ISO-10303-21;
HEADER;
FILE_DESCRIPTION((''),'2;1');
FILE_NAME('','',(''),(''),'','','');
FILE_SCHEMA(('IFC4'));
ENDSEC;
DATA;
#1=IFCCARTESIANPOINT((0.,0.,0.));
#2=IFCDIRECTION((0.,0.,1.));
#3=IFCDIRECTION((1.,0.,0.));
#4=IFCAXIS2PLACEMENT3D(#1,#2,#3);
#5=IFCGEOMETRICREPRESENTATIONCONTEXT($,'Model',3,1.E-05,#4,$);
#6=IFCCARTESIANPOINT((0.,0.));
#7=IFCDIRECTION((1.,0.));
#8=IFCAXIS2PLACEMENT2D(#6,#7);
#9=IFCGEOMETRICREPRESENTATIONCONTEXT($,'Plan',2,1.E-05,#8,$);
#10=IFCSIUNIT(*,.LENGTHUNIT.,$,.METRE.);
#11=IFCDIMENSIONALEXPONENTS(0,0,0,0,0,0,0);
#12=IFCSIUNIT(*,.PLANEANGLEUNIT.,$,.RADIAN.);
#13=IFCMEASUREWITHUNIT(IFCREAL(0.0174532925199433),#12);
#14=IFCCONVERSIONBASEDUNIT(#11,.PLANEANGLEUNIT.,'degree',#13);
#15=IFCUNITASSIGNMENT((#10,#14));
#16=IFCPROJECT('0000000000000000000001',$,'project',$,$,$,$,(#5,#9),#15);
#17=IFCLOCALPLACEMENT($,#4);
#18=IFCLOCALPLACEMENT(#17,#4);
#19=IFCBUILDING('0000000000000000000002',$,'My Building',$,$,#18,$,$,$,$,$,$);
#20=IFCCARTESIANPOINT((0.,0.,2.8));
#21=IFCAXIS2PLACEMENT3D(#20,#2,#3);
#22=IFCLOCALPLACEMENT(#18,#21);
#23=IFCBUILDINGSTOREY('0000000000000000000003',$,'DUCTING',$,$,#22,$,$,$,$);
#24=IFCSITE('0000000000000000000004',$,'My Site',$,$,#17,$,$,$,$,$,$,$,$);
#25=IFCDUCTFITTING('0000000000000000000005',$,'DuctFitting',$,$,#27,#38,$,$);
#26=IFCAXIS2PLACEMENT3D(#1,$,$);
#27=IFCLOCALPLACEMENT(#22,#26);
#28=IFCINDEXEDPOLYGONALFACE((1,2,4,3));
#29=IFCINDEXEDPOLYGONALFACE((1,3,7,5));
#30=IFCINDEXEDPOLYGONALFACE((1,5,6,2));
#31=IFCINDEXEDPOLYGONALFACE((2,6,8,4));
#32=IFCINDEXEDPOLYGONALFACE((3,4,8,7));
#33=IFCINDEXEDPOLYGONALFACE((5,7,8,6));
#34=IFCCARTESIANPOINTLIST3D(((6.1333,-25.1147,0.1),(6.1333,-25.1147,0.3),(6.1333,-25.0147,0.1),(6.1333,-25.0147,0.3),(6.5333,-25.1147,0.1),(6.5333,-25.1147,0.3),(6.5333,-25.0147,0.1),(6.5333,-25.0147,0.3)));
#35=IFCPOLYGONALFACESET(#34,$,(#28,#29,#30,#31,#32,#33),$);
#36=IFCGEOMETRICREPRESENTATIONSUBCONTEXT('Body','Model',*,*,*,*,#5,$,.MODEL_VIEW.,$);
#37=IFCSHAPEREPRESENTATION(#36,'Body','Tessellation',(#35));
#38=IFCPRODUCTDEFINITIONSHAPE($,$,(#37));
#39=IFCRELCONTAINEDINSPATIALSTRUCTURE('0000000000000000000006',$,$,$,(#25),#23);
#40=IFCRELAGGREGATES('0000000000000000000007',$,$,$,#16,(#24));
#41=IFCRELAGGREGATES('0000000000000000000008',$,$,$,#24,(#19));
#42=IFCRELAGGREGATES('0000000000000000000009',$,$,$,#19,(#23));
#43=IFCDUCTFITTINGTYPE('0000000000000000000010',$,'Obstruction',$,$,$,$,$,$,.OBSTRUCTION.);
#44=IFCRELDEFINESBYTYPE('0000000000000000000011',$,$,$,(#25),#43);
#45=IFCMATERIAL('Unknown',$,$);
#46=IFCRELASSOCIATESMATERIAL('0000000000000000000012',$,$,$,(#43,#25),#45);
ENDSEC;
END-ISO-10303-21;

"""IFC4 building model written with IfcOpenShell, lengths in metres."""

from ifc_helpers import new_model, entity, si_unit, converted_unit, frame, origin_with_axes, origin_2d_with_axis, place, context, subcontext, project, spatial, rectangle, extrude, material, material_profile, profile_set, profile_usage, type_object, element, save


model = new_model("IFC4")

# Units and contexts
model_context = context("Model", 3, precision=1e-05, world=origin_with_axes())
plan_context = context("Plan", 2, precision=1e-05, world=origin_2d_with_axis())
body_context = subcontext(model_context, "Body", "Model", "MODEL_VIEW")
ifc_project = project(units=[si_unit("LENGTHUNIT", "METRE"), converted_unit("PLANEANGLEUNIT", "degree", entity("IfcReal", 0.0174532925199433), si_unit("PLANEANGLEUNIT", "RADIAN"), dimensions=[0, 0, 0, 0, 0, 0, 0])], contexts=[model_context, plan_context])

# Site, building, storey
site_placement = place(None, origin_with_axes())
site = spatial("IfcSite", under=ifc_project, at=site_placement, Name="My Site")
building_placement = place(site_placement, origin_with_axes())
building = spatial("IfcBuilding", under=site, at=building_placement, Name="My Building")
storey_placement = place(building_placement, frame((0.0, 0.0, 2.8), z_axis=(0.0, 0.0, 1.0), x_axis=(1.0, 0.0, 0.0)))
storey = spatial("IfcBuildingStorey", under=building, at=storey_placement, Name="DUCTING")

# Shared definitions
ifc_material = material(Name="Unknown")

# Duct fitting
ifc_material_profile_1 = material_profile(ifc_material, rectangle(XDim=0.4, YDim=0.2))
ifc_profile_set_1 = profile_set([ifc_material_profile_1])
duct_fitting_type_1 = type_object("IfcDuctFittingType", Name="Obstruction", PredefinedType="OBSTRUCTION", material=ifc_profile_set_1)
ifc_profile_usage_1 = profile_usage(ifc_profile_set_1, cardinal=5)
duct_fitting_1_placement = place(storey_placement, frame((6.3333, -25.0147, 0.2), z_axis=(0.0, -1.0, 0.0), x_axis=(1.0, 0.0, 0.0)))
element("IfcDuctFitting", 1, at=duct_fitting_1_placement, inside=storey, type_object=duct_fitting_type_1, material=ifc_profile_usage_1, Name="DuctFitting", context=body_context, shape_type="SweptSolid", body=[
    extrude(rectangle(XDim=0.4, YDim=0.2), origin_with_axes(), (0.0, 0.0, 1.0), 0.1),
])

save(model, "model.ifc")
